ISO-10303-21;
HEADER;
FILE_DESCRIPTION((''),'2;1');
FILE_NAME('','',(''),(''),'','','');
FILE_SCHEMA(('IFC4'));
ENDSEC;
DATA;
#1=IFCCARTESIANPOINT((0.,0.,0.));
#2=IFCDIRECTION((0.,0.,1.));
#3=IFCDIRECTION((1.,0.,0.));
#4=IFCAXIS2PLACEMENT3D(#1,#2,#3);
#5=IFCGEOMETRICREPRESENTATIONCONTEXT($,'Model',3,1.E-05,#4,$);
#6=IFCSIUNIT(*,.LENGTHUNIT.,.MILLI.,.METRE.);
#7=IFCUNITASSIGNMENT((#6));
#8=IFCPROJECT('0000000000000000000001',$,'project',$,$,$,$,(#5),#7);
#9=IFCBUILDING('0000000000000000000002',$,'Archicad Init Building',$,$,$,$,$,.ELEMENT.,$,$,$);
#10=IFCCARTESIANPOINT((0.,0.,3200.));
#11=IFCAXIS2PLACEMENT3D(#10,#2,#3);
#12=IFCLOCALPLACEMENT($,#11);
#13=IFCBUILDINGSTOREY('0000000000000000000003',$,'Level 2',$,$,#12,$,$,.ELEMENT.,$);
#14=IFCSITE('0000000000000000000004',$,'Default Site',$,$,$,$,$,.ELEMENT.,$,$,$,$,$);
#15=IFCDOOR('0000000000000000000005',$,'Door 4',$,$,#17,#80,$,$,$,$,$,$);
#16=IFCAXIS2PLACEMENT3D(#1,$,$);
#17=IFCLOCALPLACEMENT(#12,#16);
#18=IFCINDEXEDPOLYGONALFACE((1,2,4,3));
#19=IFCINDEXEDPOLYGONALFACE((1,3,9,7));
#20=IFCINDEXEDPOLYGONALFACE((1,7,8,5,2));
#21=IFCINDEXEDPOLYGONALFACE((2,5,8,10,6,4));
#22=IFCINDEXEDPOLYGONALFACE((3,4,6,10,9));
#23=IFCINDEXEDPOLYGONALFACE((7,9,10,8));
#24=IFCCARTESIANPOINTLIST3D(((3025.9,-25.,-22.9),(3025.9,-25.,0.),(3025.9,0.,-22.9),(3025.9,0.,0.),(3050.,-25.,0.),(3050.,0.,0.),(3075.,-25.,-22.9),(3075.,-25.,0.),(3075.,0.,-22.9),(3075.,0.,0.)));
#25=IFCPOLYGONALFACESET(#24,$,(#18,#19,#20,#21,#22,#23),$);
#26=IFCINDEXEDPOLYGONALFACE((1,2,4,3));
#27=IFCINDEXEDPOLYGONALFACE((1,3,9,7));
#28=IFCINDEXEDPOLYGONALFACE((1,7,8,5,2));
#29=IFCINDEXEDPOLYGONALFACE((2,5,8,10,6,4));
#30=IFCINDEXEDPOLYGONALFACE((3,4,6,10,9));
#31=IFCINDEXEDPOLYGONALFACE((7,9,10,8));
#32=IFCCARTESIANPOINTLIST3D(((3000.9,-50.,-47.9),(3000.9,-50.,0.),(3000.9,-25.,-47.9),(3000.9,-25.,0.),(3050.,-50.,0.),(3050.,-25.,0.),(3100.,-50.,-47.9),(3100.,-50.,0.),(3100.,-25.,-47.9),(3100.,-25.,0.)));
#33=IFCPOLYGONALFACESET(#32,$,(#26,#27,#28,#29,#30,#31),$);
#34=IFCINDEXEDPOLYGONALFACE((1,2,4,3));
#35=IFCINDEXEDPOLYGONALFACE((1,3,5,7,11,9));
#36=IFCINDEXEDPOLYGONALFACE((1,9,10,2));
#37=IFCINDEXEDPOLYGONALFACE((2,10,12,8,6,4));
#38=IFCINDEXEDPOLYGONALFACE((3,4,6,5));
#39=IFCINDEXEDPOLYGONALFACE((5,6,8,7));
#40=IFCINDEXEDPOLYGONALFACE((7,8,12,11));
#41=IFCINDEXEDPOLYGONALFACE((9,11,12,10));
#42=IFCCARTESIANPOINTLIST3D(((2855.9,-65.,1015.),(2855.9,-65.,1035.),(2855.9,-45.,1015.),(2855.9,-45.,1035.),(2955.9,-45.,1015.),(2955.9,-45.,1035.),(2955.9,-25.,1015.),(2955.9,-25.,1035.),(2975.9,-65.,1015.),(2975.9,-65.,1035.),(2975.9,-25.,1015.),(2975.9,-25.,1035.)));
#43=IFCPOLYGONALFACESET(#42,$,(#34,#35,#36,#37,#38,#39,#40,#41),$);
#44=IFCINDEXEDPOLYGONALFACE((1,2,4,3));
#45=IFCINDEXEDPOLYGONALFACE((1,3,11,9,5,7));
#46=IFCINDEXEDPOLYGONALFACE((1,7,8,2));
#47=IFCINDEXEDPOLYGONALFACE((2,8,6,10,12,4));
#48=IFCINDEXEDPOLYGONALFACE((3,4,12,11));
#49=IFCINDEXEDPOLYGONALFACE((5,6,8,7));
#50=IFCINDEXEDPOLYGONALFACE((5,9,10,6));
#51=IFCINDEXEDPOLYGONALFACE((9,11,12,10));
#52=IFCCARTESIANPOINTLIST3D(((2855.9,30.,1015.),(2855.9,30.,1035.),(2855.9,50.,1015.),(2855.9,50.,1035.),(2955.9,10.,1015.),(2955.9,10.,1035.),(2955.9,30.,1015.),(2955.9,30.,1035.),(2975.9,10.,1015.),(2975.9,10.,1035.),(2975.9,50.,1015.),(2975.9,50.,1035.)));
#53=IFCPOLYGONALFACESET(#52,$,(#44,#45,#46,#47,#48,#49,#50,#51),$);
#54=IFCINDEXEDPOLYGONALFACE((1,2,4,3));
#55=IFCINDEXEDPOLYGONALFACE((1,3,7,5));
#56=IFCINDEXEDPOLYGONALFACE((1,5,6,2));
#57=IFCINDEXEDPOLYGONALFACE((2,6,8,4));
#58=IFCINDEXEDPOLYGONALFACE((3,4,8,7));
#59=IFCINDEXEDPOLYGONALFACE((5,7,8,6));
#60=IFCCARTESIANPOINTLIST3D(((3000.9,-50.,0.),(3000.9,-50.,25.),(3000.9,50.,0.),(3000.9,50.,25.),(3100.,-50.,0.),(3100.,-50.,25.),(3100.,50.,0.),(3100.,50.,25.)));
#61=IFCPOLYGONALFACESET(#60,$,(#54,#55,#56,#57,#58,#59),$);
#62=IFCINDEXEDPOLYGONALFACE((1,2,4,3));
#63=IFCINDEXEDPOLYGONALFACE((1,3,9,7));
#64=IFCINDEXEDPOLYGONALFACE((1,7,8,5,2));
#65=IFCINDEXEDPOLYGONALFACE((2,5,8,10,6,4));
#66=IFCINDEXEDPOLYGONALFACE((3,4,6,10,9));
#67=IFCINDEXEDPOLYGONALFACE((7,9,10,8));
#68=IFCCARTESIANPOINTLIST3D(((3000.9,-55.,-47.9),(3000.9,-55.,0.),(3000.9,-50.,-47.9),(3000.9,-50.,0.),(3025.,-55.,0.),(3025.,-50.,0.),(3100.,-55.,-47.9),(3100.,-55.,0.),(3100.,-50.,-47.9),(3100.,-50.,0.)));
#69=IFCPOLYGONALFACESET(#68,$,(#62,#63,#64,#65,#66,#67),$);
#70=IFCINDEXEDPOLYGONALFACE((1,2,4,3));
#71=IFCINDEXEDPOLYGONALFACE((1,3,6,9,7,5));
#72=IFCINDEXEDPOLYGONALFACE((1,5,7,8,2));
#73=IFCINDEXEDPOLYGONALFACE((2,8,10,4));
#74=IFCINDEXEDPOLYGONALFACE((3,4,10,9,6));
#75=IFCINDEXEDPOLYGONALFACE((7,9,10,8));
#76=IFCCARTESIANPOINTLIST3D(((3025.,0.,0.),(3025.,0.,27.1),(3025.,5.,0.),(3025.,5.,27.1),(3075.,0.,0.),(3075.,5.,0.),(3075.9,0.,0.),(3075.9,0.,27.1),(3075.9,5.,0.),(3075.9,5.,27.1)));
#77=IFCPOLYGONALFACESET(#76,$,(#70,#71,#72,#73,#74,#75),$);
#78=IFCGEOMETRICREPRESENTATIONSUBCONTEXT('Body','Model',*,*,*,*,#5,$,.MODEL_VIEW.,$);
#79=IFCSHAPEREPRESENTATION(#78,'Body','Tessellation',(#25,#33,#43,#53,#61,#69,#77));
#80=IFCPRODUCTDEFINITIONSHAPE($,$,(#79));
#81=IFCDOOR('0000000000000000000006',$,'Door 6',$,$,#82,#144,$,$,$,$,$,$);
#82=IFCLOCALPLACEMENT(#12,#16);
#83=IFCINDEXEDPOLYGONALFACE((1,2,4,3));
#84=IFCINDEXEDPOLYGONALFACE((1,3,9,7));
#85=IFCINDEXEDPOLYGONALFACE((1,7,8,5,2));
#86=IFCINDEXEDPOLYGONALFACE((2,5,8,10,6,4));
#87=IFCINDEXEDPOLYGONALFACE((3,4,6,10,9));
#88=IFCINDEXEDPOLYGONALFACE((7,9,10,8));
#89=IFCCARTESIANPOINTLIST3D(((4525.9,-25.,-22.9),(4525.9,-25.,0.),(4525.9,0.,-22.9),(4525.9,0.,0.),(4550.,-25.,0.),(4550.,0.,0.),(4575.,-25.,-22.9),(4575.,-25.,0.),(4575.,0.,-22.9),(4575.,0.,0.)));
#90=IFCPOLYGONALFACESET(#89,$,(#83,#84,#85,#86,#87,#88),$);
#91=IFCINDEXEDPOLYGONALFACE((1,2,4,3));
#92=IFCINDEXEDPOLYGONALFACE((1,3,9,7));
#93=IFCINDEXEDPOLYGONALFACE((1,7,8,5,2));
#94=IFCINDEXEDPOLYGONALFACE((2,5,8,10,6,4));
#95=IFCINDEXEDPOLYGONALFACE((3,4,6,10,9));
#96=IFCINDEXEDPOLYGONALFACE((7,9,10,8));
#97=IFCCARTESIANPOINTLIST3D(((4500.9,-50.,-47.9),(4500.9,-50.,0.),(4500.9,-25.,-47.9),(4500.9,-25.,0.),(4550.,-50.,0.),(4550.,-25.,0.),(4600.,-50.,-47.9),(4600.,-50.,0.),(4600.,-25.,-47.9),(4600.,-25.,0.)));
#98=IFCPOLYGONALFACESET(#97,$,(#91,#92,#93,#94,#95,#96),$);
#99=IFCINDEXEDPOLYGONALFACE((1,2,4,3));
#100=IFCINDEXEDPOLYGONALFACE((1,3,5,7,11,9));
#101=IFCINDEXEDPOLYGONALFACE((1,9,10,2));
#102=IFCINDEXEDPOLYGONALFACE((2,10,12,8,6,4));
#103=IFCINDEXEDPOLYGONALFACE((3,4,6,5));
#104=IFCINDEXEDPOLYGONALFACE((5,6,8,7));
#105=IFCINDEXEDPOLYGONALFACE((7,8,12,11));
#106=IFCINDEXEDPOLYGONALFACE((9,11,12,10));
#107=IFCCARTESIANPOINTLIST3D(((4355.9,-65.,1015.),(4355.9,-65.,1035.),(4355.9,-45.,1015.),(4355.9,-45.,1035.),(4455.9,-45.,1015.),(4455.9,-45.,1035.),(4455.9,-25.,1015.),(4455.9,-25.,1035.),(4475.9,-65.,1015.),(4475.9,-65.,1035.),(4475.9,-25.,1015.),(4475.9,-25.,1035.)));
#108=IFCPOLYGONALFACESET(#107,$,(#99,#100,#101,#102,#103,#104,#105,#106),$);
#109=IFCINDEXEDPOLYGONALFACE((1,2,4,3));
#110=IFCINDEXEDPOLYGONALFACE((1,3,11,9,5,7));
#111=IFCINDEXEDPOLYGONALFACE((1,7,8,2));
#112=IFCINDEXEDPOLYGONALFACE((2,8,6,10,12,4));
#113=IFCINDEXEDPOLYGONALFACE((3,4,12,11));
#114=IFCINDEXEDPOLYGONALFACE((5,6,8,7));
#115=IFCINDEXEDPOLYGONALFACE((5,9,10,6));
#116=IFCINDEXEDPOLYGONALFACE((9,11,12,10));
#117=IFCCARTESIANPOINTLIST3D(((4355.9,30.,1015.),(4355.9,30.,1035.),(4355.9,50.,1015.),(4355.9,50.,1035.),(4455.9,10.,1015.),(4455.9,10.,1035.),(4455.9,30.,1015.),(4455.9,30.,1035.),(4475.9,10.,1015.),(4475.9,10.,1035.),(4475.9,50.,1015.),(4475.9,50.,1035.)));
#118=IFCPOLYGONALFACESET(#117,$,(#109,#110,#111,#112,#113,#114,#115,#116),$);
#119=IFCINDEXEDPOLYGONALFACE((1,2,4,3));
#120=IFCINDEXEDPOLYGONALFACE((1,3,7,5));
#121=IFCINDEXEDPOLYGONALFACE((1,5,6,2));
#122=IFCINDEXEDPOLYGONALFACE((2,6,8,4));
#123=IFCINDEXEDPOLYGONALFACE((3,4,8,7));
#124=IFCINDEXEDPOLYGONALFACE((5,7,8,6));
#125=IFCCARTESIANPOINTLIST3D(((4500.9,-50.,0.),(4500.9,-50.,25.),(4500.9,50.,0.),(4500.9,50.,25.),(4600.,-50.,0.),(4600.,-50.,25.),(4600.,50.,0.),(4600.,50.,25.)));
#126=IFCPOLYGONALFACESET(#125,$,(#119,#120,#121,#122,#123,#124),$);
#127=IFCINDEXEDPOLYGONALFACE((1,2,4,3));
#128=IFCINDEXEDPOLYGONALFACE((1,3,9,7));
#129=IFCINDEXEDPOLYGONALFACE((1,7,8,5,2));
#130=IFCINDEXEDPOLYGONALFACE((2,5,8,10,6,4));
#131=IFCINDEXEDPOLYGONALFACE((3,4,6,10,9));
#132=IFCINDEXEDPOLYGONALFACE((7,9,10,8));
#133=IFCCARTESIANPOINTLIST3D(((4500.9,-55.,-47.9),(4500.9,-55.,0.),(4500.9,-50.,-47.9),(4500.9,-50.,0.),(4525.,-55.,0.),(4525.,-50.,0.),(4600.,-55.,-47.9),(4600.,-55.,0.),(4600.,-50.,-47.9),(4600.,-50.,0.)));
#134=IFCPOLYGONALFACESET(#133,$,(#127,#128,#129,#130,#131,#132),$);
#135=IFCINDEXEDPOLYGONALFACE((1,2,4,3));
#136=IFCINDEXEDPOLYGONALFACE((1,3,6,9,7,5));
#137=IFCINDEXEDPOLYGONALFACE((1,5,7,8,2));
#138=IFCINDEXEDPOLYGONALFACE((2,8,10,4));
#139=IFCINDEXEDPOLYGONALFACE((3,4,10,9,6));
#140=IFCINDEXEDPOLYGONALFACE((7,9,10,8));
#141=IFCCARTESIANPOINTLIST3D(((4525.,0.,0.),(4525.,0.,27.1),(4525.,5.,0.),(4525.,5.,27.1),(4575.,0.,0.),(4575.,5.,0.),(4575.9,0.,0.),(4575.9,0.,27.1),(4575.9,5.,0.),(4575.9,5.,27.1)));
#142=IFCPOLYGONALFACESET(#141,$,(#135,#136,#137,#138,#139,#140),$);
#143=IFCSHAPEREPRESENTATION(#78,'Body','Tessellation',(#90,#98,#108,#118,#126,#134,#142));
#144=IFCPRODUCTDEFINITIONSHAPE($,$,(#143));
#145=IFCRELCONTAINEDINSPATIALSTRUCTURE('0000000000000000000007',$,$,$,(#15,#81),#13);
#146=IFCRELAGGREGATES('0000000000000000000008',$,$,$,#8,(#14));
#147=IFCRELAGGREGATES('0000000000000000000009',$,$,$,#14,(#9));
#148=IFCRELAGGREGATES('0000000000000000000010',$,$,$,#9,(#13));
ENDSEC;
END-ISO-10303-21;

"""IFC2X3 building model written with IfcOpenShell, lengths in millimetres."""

from ifc_helpers import new_model, si_unit, frame, origin_with_axes, place, context, subcontext, project, spatial, polyline, outline, extrude, element, save


model = new_model("IFC2X3")

# Units and contexts
model_context = context("Model", 3, precision=1e-05, world=origin_with_axes())
body_context = subcontext(model_context, "Body", "Model", "MODEL_VIEW")
ifc_project = project(units=[si_unit("LENGTHUNIT", "METRE", prefix="MILLI")], contexts=[model_context])

# Site, building, storey
site = spatial("IfcSite", under=ifc_project, Name="Default Site", CompositionType="ELEMENT")
building = spatial("IfcBuilding", under=site, Name="Archicad Init Building", CompositionType="ELEMENT")
storey_placement = place(None, frame((0.0, 0.0, 3200.0), z_axis=(0.0, 0.0, 1.0), x_axis=(1.0, 0.0, 0.0)))
storey = spatial("IfcBuildingStorey", under=building, at=storey_placement, Name="Level 2", CompositionType="ELEMENT")

# Doors
door_1_placement = place(storey_placement, frame((3050.0, -50.0, 0.0), z_axis=(0.0, 0.0, 1.0), x_axis=(1.0, 0.0, 0.0)))
element("IfcDoor", 1, at=door_1_placement, inside=storey, Name="Door 4", context=body_context, shape_type="SweptSolid", body=[
    extrude(outline(polyline([(0.0, 0.0), (0.0, 2.1), (0.9, 2.1), (0.9, 0.0), (-24.1, 0.0), (-24.1, -22.9), (25.0, -22.9), (25.0, 0.0), (0.0, 0.0)])), frame((0.0, 25.0, 0.0), z_axis=(0.0, -1.0, 0.0), x_axis=(1.0, 0.0, 0.0)), (0.0, 0.0, -1.0), 25.0),
    extrude(outline(polyline([(0.0, 0.0), (0.0, 2.1), (0.9, 2.1), (0.9, 0.0), (-49.1, 0.0), (-49.1, -47.9), (50.0, -47.9), (50.0, 0.0), (0.0, 0.0)])), frame((0.0, 0.0, 0.0), z_axis=(0.0, -1.0, 0.0), x_axis=(1.0, 0.0, 0.0)), (0.0, 0.0, -1.0), 25.0),
    extrude(outline(polyline([(0.0, 0.0), (-49.1, 0.0), (-49.1, 35.0), (0.0, 35.0), (0.0, 0.0)])), frame((25.0, 25.0, 25.0), z_axis=(0.0, 0.0, 1.0), x_axis=(1.0, 0.0, 0.0)), (0.0, 0.0, 1.0), -47.9),
    extrude(outline(polyline([(0.0, 0.0), (0.0, -40.0), (-120.0, -40.0), (-120.0, -20.0), (-20.0, -20.0), (-20.0, 0.0), (0.0, 0.0)])), frame((-74.1, 25.0, 1015.0), z_axis=(0.0, 0.0, 1.0), x_axis=(1.0, 0.0, 0.0)), (0.0, 0.0, 1.0), 20.0),
    extrude(outline(polyline([(0.0, 0.0), (0.0, 40.0), (-120.0, 40.0), (-120.0, 20.0), (-20.0, 20.0), (-20.0, 0.0), (0.0, 0.0)])), frame((-74.1, 60.0, 1015.0), z_axis=(0.0, 0.0, 1.0), x_axis=(1.0, 0.0, 0.0)), (0.0, 0.0, 1.0), 20.0),
    extrude(outline(polyline([(0.0, 0.0), (-99.1, 0.0), (-99.1, 100.0), (0.0, 100.0), (0.0, 0.0)])), frame((50.0, 0.0, 0.0), z_axis=(0.0, 0.0, 1.0), x_axis=(1.0, 0.0, 0.0)), (0.0, 0.0, 1.0), 25.0),
    extrude(outline(polyline([(0.0, 0.0), (0.0, 27.1), (50.9, 27.1), (50.9, 0.0), (-24.1, 0.0), (-24.1, -47.9), (75.0, -47.9), (75.0, 0.0), (0.0, 0.0)])), frame((-25.0, -5.0, 0.0), z_axis=(0.0, -1.0, 0.0), x_axis=(1.0, 0.0, 0.0)), (0.0, 0.0, -1.0), 5.0),
    extrude(outline(polyline([(0.0, 0.0), (0.0, 27.1), (50.9, 27.1), (50.9, 0.0), (0.9, 0.0), (0.9, -22.9), (50.0, -22.9), (50.0, 0.0), (0.0, 0.0)])), frame((-25.0, 50.0, 0.0), z_axis=(0.0, -1.0, 0.0), x_axis=(1.0, 0.0, 0.0)), (0.0, 0.0, -1.0), 5.0),
])
door_2_placement = place(storey_placement, frame((4550.0, -50.0, 0.0), z_axis=(0.0, 0.0, 1.0), x_axis=(1.0, 0.0, 0.0)))
element("IfcDoor", 2, at=door_2_placement, inside=storey, Name="Door 6", context=body_context, shape_type="SweptSolid", body=[
    extrude(outline(polyline([(0.0, 0.0), (0.0, 2.1), (0.9, 2.1), (0.9, 0.0), (-24.1, 0.0), (-24.1, -22.9), (25.0, -22.9), (25.0, 0.0), (0.0, 0.0)])), frame((0.0, 25.0, 0.0), z_axis=(0.0, -1.0, 0.0), x_axis=(1.0, 0.0, 0.0)), (0.0, 0.0, -1.0), 25.0),
    extrude(outline(polyline([(0.0, 0.0), (0.0, 2.1), (0.9, 2.1), (0.9, 0.0), (-49.1, 0.0), (-49.1, -47.9), (50.0, -47.9), (50.0, 0.0), (0.0, 0.0)])), frame((0.0, 0.0, 0.0), z_axis=(0.0, -1.0, 0.0), x_axis=(1.0, 0.0, 0.0)), (0.0, 0.0, -1.0), 25.0),
    extrude(outline(polyline([(0.0, 0.0), (-49.1, 0.0), (-49.1, 35.0), (0.0, 35.0), (0.0, 0.0)])), frame((25.0, 25.0, 25.0), z_axis=(0.0, 0.0, 1.0), x_axis=(1.0, 0.0, 0.0)), (0.0, 0.0, 1.0), -47.9),
    extrude(outline(polyline([(0.0, 0.0), (0.0, -40.0), (-120.0, -40.0), (-120.0, -20.0), (-20.0, -20.0), (-20.0, 0.0), (0.0, 0.0)])), frame((-74.1, 25.0, 1015.0), z_axis=(0.0, 0.0, 1.0), x_axis=(1.0, 0.0, 0.0)), (0.0, 0.0, 1.0), 20.0),
    extrude(outline(polyline([(0.0, 0.0), (0.0, 40.0), (-120.0, 40.0), (-120.0, 20.0), (-20.0, 20.0), (-20.0, 0.0), (0.0, 0.0)])), frame((-74.1, 60.0, 1015.0), z_axis=(0.0, 0.0, 1.0), x_axis=(1.0, 0.0, 0.0)), (0.0, 0.0, 1.0), 20.0),
    extrude(outline(polyline([(0.0, 0.0), (-99.1, 0.0), (-99.1, 100.0), (0.0, 100.0), (0.0, 0.0)])), frame((50.0, 0.0, 0.0), z_axis=(0.0, 0.0, 1.0), x_axis=(1.0, 0.0, 0.0)), (0.0, 0.0, 1.0), 25.0),
    extrude(outline(polyline([(0.0, 0.0), (0.0, 27.1), (50.9, 27.1), (50.9, 0.0), (-24.1, 0.0), (-24.1, -47.9), (75.0, -47.9), (75.0, 0.0), (0.0, 0.0)])), frame((-25.0, -5.0, 0.0), z_axis=(0.0, -1.0, 0.0), x_axis=(1.0, 0.0, 0.0)), (0.0, 0.0, -1.0), 5.0),
    extrude(outline(polyline([(0.0, 0.0), (0.0, 27.1), (50.9, 27.1), (50.9, 0.0), (0.9, 0.0), (0.9, -22.9), (50.0, -22.9), (50.0, 0.0), (0.0, 0.0)])), frame((-25.0, 50.0, 0.0), z_axis=(0.0, -1.0, 0.0), x_axis=(1.0, 0.0, 0.0)), (0.0, 0.0, -1.0), 5.0),
])

save(model, "model.ifc")
